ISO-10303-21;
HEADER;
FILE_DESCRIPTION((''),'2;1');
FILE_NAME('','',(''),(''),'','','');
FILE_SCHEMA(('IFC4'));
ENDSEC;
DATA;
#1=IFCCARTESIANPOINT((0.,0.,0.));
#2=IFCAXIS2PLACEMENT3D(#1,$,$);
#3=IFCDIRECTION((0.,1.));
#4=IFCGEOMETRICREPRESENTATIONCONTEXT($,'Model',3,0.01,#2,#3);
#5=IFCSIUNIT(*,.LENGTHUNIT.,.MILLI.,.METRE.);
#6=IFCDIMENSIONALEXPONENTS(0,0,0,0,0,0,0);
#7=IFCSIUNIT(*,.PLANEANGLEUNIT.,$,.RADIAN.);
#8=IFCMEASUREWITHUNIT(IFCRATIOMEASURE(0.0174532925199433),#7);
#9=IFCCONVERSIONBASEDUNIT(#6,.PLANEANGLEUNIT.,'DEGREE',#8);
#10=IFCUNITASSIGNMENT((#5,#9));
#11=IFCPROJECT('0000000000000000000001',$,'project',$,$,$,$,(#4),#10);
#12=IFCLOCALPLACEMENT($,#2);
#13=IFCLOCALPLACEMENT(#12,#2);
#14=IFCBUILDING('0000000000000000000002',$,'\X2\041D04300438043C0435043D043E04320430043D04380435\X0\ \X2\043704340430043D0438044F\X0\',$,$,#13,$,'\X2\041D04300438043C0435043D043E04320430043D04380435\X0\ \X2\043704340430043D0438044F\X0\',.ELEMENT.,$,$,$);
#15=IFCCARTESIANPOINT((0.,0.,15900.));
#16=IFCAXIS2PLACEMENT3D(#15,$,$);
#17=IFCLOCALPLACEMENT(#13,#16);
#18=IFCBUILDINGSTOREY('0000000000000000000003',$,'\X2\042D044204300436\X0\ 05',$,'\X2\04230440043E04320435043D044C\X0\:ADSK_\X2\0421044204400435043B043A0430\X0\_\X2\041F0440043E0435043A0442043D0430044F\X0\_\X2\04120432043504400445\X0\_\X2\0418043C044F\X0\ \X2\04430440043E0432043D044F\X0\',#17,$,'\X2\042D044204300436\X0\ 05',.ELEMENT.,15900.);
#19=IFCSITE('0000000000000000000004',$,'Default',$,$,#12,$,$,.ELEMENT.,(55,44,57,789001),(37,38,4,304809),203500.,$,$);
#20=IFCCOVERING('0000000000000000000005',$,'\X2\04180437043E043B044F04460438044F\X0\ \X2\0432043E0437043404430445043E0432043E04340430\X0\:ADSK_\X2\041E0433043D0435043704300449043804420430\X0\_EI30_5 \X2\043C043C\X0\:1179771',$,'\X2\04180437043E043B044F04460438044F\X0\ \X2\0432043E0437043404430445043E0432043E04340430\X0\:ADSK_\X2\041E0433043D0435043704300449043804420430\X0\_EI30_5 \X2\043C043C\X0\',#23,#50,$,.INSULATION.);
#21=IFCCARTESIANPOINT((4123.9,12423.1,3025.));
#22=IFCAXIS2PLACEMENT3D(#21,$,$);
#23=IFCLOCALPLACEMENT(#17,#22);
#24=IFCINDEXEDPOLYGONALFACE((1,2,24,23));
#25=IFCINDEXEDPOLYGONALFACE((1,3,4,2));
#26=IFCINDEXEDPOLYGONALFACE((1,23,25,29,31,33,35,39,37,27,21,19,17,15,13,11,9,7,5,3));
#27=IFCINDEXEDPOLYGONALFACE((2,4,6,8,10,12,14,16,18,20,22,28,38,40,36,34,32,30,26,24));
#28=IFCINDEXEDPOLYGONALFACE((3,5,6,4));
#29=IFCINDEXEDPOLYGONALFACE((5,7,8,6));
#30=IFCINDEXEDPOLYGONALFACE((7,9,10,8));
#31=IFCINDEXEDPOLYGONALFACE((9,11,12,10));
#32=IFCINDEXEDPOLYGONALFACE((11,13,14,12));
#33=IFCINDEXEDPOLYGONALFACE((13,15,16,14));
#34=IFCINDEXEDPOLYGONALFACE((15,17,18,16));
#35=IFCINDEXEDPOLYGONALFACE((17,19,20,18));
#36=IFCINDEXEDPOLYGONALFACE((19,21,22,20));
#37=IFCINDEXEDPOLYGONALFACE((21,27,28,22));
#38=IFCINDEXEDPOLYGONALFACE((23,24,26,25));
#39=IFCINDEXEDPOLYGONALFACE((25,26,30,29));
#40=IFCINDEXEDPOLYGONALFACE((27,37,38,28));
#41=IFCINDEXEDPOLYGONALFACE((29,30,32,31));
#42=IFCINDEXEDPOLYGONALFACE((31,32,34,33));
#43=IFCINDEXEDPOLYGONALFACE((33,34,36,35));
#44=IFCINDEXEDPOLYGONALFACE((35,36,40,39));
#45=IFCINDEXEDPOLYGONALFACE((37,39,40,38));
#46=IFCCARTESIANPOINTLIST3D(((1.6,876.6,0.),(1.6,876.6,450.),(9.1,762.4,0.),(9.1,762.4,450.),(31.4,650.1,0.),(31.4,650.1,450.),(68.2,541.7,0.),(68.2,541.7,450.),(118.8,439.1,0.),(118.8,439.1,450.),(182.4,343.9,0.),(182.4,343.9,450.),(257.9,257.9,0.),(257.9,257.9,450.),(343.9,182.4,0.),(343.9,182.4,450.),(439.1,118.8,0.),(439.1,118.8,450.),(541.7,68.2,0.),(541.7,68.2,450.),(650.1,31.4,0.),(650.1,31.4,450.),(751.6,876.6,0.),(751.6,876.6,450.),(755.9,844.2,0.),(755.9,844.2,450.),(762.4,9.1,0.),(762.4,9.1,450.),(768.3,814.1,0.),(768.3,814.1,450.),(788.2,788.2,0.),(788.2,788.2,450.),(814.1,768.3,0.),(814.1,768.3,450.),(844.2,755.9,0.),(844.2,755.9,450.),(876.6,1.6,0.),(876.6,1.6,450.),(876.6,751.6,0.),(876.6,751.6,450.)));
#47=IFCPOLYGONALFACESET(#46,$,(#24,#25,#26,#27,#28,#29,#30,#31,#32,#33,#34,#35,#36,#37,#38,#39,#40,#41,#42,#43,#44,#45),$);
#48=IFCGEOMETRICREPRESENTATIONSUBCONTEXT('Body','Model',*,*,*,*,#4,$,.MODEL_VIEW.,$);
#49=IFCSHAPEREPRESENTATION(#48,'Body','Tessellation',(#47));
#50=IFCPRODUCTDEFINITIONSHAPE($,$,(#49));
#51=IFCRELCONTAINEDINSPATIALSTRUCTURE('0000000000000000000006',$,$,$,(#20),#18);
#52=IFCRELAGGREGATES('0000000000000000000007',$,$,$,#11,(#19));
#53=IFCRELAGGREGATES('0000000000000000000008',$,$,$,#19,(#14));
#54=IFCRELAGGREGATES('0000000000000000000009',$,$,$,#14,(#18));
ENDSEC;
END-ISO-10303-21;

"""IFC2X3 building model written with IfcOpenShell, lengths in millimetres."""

from ifc_helpers import new_model, entity, si_unit, converted_unit, direction, frame, frame_2d, origin, place, context, subcontext, project, spatial, polyline, circle_curve, parameter, trimmed, segment, composite_curve, outline, extrude, element, save


model = new_model("IFC2X3")

# Units and contexts
model_context = context("Model", 3, precision=0.01, world=origin(), true_north=direction((0.0, 1.0)))
body_context = subcontext(model_context, "Body", "Model", "MODEL_VIEW")
ifc_project = project(units=[si_unit("LENGTHUNIT", "METRE", prefix="MILLI"), converted_unit("PLANEANGLEUNIT", "DEGREE", entity("IfcRatioMeasure", 0.0174532925199433), si_unit("PLANEANGLEUNIT", "RADIAN"), dimensions=[0, 0, 0, 0, 0, 0, 0])], contexts=[model_context])

# Site, building, storey
site_placement = place(None, frame((0.0, 0.0, 0.0)))
site = spatial("IfcSite", under=ifc_project, at=site_placement, Name="Default", CompositionType="ELEMENT", RefLatitude=(55, 44, 57, 789001), RefLongitude=(37, 38, 4, 304809), RefElevation=203500.0)
building_placement = place(site_placement, origin())
building = spatial("IfcBuilding", under=site, at=building_placement, Name="Наименование здания", LongName="Наименование здания", CompositionType="ELEMENT")
storey_placement = place(building_placement, frame((0.0, 0.0, 15900.0)))
storey = spatial("IfcBuildingStorey", under=building, at=storey_placement, Name="Этаж 05", ObjectType="Уровень:ADSK_Стрелка_Проектная_Вверх_Имя уровня", LongName="Этаж 05", CompositionType="ELEMENT", Elevation=15900.0)

# Covering
covering_1_placement = place(storey_placement, frame((4123.9, 12423.1, 3025.0)))
element("IfcCovering", 1, at=covering_1_placement, inside=storey, Name="Изоляция воздуховода:ADSK_Огнезащита_EI30_5 мм:1179771", ObjectType="Изоляция воздуховода:ADSK_Огнезащита_EI30_5 мм", PredefinedType="INSULATION", context=body_context, shape_type="SweptSolid", body=[
    extrude(outline(composite_curve([segment(polyline([(-250.0, 125.0), (-250.0, -625.0)]), True, "CONTINUOUS"), segment(trimmed(circle_curve(frame_2d((-250.0, 250.0), x_axis=(1.0, 0.0)), 875.0), [parameter(270.0)], [parameter(0.0)], True, "PARAMETER"), True, "CONTINUOUS"), segment(polyline([(625.0, 250.0), (-125.0, 250.0)]), True, "CONTINUOUS"), segment(trimmed(circle_curve(frame_2d((-250.0, 250.0), x_axis=(1.0, 0.0)), 125.0), [parameter(270.0)], [parameter(360.0)], True, "PARAMETER"), False, "CONTINUOUS")], self_intersect=False)), frame((626.6, 626.6, 0.0), z_axis=(0.0, 0.0, -1.0), x_axis=(-1.0, 0.0, 0.0)), (0.0, 0.0, -1.0), 450.0),
])

save(model, "model.ifc")
